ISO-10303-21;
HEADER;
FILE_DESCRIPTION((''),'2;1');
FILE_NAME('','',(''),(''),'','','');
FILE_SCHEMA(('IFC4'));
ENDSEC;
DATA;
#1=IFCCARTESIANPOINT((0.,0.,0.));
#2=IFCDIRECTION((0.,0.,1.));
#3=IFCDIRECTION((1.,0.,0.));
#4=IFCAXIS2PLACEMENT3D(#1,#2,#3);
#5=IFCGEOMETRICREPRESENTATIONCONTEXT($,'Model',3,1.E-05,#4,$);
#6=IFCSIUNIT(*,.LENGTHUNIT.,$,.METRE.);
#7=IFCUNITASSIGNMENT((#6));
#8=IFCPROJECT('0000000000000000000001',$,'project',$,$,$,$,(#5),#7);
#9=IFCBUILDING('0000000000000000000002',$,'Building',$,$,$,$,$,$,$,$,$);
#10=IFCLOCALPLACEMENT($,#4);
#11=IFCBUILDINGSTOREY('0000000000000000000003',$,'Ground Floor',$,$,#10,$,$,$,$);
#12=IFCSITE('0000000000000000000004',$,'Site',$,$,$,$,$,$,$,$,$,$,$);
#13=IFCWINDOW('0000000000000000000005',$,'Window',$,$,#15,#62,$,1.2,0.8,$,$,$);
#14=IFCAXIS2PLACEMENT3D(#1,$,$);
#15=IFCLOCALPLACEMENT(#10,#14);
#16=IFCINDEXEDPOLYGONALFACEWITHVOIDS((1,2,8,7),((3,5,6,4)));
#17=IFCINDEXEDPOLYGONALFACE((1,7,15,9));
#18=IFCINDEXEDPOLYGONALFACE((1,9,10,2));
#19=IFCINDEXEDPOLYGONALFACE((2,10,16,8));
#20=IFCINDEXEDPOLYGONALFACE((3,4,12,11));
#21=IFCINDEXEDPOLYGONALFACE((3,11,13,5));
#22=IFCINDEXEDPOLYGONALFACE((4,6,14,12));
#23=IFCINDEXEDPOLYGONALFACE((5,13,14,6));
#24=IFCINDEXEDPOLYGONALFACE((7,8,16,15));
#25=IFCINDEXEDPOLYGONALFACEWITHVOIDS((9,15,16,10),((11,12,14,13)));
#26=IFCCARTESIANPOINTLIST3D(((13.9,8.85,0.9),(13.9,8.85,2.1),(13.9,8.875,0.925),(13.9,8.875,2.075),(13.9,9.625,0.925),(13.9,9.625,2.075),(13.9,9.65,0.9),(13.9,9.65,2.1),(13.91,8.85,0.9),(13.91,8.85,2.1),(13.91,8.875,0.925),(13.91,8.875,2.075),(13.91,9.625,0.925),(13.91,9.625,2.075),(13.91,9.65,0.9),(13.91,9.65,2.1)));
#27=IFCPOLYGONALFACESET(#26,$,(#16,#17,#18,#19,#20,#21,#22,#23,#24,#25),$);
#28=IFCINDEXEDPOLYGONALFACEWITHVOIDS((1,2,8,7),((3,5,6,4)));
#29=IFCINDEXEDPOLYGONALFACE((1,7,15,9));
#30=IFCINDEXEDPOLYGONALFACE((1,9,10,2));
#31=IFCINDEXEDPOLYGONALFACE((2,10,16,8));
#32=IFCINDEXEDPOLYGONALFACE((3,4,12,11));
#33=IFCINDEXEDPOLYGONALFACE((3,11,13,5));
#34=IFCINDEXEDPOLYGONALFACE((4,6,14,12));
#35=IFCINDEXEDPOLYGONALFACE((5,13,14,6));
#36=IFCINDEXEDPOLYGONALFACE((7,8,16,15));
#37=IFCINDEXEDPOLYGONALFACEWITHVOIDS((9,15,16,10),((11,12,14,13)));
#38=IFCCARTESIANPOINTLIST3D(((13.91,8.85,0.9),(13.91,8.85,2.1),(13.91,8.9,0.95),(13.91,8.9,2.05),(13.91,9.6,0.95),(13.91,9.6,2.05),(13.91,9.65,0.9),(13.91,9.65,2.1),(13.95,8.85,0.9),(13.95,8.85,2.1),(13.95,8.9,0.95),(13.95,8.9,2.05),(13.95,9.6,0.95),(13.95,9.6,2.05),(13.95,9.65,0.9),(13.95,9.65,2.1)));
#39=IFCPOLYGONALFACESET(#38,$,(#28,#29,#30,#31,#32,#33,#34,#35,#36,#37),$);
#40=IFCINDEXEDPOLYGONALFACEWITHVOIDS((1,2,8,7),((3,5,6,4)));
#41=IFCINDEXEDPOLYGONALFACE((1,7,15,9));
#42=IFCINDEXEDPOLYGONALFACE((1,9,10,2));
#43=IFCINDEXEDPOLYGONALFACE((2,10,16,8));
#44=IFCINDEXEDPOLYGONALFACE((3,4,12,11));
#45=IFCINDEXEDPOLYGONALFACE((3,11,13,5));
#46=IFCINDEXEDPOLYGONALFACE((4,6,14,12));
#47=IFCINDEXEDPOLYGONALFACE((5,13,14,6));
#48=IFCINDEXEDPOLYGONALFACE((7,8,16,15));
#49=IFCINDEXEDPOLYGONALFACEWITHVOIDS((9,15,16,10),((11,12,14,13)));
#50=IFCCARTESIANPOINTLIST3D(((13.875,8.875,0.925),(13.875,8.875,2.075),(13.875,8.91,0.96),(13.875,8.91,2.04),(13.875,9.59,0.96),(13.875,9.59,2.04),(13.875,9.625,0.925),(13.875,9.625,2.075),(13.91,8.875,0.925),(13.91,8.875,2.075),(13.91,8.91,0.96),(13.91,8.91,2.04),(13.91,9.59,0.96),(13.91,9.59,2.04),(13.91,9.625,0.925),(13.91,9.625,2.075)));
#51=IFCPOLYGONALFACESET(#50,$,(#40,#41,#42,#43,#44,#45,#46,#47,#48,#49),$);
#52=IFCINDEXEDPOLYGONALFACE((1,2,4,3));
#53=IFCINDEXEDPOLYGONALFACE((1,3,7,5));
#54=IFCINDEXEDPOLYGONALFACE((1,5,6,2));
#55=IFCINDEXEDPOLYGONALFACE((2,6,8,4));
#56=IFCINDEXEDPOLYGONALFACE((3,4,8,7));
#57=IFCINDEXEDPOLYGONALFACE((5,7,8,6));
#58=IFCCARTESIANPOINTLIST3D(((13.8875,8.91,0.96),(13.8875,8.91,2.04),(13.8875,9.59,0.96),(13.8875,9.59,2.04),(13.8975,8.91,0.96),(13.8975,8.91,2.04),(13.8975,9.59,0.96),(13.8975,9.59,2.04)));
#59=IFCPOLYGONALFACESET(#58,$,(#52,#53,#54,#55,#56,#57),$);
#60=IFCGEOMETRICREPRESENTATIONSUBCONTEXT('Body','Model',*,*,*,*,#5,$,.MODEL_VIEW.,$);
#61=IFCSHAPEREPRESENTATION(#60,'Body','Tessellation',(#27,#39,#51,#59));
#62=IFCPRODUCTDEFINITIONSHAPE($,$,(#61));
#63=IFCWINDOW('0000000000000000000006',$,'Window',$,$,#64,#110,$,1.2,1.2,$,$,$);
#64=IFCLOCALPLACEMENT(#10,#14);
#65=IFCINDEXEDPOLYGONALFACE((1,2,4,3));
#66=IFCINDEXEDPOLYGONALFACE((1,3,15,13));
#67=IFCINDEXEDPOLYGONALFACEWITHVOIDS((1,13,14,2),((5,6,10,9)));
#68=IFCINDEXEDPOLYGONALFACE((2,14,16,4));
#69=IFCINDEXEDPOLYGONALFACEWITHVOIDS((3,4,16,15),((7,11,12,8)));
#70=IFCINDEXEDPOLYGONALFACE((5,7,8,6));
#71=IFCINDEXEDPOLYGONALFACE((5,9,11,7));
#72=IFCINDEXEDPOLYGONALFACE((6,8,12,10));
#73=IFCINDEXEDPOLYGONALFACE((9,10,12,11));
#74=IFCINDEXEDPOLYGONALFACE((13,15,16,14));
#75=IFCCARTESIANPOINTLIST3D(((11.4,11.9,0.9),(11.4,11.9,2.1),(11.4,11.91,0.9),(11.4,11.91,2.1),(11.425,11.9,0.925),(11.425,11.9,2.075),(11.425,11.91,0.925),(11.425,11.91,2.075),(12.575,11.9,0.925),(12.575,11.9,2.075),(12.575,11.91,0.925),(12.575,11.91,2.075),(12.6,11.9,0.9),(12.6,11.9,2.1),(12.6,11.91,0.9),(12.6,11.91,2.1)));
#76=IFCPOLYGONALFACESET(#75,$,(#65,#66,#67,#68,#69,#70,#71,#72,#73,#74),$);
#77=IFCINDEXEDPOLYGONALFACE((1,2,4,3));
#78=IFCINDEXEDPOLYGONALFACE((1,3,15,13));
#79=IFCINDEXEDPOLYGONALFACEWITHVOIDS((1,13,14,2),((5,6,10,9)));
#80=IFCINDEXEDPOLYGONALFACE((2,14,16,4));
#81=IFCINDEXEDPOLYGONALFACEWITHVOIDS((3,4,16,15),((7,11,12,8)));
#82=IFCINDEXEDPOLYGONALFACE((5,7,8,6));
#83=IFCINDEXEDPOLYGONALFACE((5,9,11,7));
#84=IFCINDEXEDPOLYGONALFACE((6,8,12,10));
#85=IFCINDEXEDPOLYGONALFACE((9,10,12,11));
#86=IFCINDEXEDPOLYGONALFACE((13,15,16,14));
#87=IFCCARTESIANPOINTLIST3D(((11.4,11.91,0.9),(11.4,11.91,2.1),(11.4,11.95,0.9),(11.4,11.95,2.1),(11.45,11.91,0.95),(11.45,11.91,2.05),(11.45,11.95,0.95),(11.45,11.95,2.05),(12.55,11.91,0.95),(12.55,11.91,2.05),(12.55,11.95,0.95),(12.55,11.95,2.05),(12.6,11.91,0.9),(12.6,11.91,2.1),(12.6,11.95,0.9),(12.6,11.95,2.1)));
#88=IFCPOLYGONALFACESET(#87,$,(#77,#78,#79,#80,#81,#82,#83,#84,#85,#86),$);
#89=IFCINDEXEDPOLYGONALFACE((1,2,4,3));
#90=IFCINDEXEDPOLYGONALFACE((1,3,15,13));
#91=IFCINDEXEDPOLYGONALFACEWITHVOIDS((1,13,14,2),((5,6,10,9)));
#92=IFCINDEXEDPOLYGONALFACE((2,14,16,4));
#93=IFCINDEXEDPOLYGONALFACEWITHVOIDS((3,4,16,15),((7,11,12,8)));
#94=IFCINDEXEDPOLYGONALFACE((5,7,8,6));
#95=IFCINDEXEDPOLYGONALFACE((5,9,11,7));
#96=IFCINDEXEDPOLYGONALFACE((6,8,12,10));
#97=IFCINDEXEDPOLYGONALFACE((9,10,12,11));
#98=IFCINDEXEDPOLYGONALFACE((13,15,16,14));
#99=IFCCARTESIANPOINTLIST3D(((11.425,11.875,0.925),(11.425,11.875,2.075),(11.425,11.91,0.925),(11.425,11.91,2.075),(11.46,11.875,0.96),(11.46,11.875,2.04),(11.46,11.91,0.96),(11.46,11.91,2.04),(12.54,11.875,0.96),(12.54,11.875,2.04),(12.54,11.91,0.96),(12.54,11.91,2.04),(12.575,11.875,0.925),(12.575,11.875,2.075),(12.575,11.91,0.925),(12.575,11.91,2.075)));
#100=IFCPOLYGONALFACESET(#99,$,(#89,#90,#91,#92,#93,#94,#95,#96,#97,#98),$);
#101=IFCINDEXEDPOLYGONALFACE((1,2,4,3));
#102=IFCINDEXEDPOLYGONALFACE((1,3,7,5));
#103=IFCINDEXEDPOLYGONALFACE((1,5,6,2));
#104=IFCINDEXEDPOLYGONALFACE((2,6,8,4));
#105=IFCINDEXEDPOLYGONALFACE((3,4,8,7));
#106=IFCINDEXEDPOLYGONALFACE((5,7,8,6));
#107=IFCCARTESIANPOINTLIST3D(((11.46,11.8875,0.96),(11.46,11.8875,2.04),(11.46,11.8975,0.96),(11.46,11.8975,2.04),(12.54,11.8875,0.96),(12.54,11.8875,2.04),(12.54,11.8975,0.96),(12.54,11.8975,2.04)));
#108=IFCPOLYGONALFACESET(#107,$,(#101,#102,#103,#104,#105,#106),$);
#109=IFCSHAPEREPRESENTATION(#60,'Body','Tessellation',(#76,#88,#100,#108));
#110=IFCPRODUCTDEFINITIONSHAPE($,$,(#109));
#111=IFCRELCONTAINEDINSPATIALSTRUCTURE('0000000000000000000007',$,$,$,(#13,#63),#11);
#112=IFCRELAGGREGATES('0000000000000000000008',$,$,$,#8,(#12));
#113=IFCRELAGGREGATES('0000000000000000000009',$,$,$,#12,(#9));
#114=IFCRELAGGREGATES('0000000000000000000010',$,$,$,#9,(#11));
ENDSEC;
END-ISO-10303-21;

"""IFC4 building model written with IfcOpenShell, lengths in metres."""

from ifc_helpers import new_model, si_unit, frame, origin_with_axes, place, context, subcontext, project, spatial, line, indexed_curve, outline, extrude, element, save


model = new_model("IFC4")

# Units and contexts
model_context = context("Model", 3, precision=1e-05, world=origin_with_axes())
body_context = subcontext(model_context, "Body", "Model", "MODEL_VIEW")
ifc_project = project(units=[si_unit("LENGTHUNIT", "METRE")], contexts=[model_context])

# Site, building, storey
site = spatial("IfcSite", under=ifc_project, Name="Site")
building = spatial("IfcBuilding", under=site, Name="Building")
storey_placement = place(None, origin_with_axes())
storey = spatial("IfcBuildingStorey", under=building, at=storey_placement, Name="Ground Floor")

# Windows
window_1_placement = place(storey_placement, frame((14.0, 8.85, 0.9), z_axis=(0.0, 0.0, 1.0), x_axis=(0.0, 1.0, 0.0)))
element("IfcWindow", 1, at=window_1_placement, inside=storey, Name="Window", OverallHeight=1.2, OverallWidth=0.8, context=body_context, shape_type="SweptSolid", body=[
    extrude(outline(indexed_curve([(0.0, 0.0), (0.8, 0.0), (0.8, 1.2), (0.0, 1.2)], segments=[line(1, 2, 3, 4, 1)]), holes=[indexed_curve([(0.025, 0.025), (0.775, 0.025), (0.775, 1.175), (0.025, 1.175)], segments=[line(1, 2, 3, 4, 1)])]), frame((0.0, 0.09, 0.0), z_axis=(0.0, -1.0, 0.0), x_axis=(1.0, 0.0, 0.0)), (0.0, 0.0, -1.0), 0.01),
    extrude(outline(indexed_curve([(0.0, 0.0), (0.8, 0.0), (0.8, 1.2), (0.0, 1.2)], segments=[line(1, 2, 3, 4, 1)]), holes=[indexed_curve([(0.05, 0.05), (0.75, 0.05), (0.75, 1.15), (0.05, 1.15)], segments=[line(1, 2, 3, 4, 1)])]), frame((0.0, 0.05, 0.0), z_axis=(0.0, -1.0, 0.0), x_axis=(1.0, 0.0, 0.0)), (0.0, 0.0, -1.0), 0.04),
    extrude(outline(indexed_curve([(0.0, 0.0), (0.75, 0.0), (0.75, 1.15), (0.0, 1.15)], segments=[line(1, 2, 3, 4, 1)]), holes=[indexed_curve([(0.035, 0.035), (0.715, 0.035), (0.715, 1.115), (0.035, 1.115)], segments=[line(1, 2, 3, 4, 1)])]), frame((0.025, 0.09, 0.025), z_axis=(0.0, -1.0, 0.0), x_axis=(1.0, 0.0, 0.0)), (0.0, 0.0, -1.0), 0.035),
    extrude(outline(indexed_curve([(0.035, 0.035), (0.715, 0.035), (0.715, 1.115), (0.035, 1.115)], segments=[line(1, 2, 3, 4, 1)])), frame((0.025, 0.1025, 0.025), z_axis=(0.0, -1.0, 0.0), x_axis=(1.0, 0.0, 0.0)), (0.0, 0.0, -1.0), 0.01),
])
window_2_placement = place(storey_placement, frame((12.6, 12.0, 0.9), z_axis=(0.0, 0.0, 1.0), x_axis=(-1.0, 0.0, 0.0)))
element("IfcWindow", 2, at=window_2_placement, inside=storey, Name="Window", OverallHeight=1.2, OverallWidth=1.2, context=body_context, shape_type="SweptSolid", body=[
    extrude(outline(indexed_curve([(0.0, 0.0), (1.2, 0.0), (1.2, 1.2), (0.0, 1.2)], segments=[line(1, 2, 3, 4, 1)]), holes=[indexed_curve([(0.025, 0.025), (1.175, 0.025), (1.175, 1.175), (0.025, 1.175)], segments=[line(1, 2, 3, 4, 1)])]), frame((0.0, 0.09, 0.0), z_axis=(0.0, -1.0, 0.0), x_axis=(1.0, 0.0, 0.0)), (0.0, 0.0, -1.0), 0.01),
    extrude(outline(indexed_curve([(0.0, 0.0), (1.2, 0.0), (1.2, 1.2), (0.0, 1.2)], segments=[line(1, 2, 3, 4, 1)]), holes=[indexed_curve([(0.05, 0.05), (1.15, 0.05), (1.15, 1.15), (0.05, 1.15)], segments=[line(1, 2, 3, 4, 1)])]), frame((0.0, 0.05, 0.0), z_axis=(0.0, -1.0, 0.0), x_axis=(1.0, 0.0, 0.0)), (0.0, 0.0, -1.0), 0.04),
    extrude(outline(indexed_curve([(0.0, 0.0), (1.15, 0.0), (1.15, 1.15), (0.0, 1.15)], segments=[line(1, 2, 3, 4, 1)]), holes=[indexed_curve([(0.035, 0.035), (1.115, 0.035), (1.115, 1.115), (0.035, 1.115)], segments=[line(1, 2, 3, 4, 1)])]), frame((0.025, 0.09, 0.025), z_axis=(0.0, -1.0, 0.0), x_axis=(1.0, 0.0, 0.0)), (0.0, 0.0, -1.0), 0.035),
    extrude(outline(indexed_curve([(0.035, 0.035), (1.115, 0.035), (1.115, 1.115), (0.035, 1.115)], segments=[line(1, 2, 3, 4, 1)])), frame((0.025, 0.1025, 0.025), z_axis=(0.0, -1.0, 0.0), x_axis=(1.0, 0.0, 0.0)), (0.0, 0.0, -1.0), 0.01),
])

save(model, "model.ifc")
